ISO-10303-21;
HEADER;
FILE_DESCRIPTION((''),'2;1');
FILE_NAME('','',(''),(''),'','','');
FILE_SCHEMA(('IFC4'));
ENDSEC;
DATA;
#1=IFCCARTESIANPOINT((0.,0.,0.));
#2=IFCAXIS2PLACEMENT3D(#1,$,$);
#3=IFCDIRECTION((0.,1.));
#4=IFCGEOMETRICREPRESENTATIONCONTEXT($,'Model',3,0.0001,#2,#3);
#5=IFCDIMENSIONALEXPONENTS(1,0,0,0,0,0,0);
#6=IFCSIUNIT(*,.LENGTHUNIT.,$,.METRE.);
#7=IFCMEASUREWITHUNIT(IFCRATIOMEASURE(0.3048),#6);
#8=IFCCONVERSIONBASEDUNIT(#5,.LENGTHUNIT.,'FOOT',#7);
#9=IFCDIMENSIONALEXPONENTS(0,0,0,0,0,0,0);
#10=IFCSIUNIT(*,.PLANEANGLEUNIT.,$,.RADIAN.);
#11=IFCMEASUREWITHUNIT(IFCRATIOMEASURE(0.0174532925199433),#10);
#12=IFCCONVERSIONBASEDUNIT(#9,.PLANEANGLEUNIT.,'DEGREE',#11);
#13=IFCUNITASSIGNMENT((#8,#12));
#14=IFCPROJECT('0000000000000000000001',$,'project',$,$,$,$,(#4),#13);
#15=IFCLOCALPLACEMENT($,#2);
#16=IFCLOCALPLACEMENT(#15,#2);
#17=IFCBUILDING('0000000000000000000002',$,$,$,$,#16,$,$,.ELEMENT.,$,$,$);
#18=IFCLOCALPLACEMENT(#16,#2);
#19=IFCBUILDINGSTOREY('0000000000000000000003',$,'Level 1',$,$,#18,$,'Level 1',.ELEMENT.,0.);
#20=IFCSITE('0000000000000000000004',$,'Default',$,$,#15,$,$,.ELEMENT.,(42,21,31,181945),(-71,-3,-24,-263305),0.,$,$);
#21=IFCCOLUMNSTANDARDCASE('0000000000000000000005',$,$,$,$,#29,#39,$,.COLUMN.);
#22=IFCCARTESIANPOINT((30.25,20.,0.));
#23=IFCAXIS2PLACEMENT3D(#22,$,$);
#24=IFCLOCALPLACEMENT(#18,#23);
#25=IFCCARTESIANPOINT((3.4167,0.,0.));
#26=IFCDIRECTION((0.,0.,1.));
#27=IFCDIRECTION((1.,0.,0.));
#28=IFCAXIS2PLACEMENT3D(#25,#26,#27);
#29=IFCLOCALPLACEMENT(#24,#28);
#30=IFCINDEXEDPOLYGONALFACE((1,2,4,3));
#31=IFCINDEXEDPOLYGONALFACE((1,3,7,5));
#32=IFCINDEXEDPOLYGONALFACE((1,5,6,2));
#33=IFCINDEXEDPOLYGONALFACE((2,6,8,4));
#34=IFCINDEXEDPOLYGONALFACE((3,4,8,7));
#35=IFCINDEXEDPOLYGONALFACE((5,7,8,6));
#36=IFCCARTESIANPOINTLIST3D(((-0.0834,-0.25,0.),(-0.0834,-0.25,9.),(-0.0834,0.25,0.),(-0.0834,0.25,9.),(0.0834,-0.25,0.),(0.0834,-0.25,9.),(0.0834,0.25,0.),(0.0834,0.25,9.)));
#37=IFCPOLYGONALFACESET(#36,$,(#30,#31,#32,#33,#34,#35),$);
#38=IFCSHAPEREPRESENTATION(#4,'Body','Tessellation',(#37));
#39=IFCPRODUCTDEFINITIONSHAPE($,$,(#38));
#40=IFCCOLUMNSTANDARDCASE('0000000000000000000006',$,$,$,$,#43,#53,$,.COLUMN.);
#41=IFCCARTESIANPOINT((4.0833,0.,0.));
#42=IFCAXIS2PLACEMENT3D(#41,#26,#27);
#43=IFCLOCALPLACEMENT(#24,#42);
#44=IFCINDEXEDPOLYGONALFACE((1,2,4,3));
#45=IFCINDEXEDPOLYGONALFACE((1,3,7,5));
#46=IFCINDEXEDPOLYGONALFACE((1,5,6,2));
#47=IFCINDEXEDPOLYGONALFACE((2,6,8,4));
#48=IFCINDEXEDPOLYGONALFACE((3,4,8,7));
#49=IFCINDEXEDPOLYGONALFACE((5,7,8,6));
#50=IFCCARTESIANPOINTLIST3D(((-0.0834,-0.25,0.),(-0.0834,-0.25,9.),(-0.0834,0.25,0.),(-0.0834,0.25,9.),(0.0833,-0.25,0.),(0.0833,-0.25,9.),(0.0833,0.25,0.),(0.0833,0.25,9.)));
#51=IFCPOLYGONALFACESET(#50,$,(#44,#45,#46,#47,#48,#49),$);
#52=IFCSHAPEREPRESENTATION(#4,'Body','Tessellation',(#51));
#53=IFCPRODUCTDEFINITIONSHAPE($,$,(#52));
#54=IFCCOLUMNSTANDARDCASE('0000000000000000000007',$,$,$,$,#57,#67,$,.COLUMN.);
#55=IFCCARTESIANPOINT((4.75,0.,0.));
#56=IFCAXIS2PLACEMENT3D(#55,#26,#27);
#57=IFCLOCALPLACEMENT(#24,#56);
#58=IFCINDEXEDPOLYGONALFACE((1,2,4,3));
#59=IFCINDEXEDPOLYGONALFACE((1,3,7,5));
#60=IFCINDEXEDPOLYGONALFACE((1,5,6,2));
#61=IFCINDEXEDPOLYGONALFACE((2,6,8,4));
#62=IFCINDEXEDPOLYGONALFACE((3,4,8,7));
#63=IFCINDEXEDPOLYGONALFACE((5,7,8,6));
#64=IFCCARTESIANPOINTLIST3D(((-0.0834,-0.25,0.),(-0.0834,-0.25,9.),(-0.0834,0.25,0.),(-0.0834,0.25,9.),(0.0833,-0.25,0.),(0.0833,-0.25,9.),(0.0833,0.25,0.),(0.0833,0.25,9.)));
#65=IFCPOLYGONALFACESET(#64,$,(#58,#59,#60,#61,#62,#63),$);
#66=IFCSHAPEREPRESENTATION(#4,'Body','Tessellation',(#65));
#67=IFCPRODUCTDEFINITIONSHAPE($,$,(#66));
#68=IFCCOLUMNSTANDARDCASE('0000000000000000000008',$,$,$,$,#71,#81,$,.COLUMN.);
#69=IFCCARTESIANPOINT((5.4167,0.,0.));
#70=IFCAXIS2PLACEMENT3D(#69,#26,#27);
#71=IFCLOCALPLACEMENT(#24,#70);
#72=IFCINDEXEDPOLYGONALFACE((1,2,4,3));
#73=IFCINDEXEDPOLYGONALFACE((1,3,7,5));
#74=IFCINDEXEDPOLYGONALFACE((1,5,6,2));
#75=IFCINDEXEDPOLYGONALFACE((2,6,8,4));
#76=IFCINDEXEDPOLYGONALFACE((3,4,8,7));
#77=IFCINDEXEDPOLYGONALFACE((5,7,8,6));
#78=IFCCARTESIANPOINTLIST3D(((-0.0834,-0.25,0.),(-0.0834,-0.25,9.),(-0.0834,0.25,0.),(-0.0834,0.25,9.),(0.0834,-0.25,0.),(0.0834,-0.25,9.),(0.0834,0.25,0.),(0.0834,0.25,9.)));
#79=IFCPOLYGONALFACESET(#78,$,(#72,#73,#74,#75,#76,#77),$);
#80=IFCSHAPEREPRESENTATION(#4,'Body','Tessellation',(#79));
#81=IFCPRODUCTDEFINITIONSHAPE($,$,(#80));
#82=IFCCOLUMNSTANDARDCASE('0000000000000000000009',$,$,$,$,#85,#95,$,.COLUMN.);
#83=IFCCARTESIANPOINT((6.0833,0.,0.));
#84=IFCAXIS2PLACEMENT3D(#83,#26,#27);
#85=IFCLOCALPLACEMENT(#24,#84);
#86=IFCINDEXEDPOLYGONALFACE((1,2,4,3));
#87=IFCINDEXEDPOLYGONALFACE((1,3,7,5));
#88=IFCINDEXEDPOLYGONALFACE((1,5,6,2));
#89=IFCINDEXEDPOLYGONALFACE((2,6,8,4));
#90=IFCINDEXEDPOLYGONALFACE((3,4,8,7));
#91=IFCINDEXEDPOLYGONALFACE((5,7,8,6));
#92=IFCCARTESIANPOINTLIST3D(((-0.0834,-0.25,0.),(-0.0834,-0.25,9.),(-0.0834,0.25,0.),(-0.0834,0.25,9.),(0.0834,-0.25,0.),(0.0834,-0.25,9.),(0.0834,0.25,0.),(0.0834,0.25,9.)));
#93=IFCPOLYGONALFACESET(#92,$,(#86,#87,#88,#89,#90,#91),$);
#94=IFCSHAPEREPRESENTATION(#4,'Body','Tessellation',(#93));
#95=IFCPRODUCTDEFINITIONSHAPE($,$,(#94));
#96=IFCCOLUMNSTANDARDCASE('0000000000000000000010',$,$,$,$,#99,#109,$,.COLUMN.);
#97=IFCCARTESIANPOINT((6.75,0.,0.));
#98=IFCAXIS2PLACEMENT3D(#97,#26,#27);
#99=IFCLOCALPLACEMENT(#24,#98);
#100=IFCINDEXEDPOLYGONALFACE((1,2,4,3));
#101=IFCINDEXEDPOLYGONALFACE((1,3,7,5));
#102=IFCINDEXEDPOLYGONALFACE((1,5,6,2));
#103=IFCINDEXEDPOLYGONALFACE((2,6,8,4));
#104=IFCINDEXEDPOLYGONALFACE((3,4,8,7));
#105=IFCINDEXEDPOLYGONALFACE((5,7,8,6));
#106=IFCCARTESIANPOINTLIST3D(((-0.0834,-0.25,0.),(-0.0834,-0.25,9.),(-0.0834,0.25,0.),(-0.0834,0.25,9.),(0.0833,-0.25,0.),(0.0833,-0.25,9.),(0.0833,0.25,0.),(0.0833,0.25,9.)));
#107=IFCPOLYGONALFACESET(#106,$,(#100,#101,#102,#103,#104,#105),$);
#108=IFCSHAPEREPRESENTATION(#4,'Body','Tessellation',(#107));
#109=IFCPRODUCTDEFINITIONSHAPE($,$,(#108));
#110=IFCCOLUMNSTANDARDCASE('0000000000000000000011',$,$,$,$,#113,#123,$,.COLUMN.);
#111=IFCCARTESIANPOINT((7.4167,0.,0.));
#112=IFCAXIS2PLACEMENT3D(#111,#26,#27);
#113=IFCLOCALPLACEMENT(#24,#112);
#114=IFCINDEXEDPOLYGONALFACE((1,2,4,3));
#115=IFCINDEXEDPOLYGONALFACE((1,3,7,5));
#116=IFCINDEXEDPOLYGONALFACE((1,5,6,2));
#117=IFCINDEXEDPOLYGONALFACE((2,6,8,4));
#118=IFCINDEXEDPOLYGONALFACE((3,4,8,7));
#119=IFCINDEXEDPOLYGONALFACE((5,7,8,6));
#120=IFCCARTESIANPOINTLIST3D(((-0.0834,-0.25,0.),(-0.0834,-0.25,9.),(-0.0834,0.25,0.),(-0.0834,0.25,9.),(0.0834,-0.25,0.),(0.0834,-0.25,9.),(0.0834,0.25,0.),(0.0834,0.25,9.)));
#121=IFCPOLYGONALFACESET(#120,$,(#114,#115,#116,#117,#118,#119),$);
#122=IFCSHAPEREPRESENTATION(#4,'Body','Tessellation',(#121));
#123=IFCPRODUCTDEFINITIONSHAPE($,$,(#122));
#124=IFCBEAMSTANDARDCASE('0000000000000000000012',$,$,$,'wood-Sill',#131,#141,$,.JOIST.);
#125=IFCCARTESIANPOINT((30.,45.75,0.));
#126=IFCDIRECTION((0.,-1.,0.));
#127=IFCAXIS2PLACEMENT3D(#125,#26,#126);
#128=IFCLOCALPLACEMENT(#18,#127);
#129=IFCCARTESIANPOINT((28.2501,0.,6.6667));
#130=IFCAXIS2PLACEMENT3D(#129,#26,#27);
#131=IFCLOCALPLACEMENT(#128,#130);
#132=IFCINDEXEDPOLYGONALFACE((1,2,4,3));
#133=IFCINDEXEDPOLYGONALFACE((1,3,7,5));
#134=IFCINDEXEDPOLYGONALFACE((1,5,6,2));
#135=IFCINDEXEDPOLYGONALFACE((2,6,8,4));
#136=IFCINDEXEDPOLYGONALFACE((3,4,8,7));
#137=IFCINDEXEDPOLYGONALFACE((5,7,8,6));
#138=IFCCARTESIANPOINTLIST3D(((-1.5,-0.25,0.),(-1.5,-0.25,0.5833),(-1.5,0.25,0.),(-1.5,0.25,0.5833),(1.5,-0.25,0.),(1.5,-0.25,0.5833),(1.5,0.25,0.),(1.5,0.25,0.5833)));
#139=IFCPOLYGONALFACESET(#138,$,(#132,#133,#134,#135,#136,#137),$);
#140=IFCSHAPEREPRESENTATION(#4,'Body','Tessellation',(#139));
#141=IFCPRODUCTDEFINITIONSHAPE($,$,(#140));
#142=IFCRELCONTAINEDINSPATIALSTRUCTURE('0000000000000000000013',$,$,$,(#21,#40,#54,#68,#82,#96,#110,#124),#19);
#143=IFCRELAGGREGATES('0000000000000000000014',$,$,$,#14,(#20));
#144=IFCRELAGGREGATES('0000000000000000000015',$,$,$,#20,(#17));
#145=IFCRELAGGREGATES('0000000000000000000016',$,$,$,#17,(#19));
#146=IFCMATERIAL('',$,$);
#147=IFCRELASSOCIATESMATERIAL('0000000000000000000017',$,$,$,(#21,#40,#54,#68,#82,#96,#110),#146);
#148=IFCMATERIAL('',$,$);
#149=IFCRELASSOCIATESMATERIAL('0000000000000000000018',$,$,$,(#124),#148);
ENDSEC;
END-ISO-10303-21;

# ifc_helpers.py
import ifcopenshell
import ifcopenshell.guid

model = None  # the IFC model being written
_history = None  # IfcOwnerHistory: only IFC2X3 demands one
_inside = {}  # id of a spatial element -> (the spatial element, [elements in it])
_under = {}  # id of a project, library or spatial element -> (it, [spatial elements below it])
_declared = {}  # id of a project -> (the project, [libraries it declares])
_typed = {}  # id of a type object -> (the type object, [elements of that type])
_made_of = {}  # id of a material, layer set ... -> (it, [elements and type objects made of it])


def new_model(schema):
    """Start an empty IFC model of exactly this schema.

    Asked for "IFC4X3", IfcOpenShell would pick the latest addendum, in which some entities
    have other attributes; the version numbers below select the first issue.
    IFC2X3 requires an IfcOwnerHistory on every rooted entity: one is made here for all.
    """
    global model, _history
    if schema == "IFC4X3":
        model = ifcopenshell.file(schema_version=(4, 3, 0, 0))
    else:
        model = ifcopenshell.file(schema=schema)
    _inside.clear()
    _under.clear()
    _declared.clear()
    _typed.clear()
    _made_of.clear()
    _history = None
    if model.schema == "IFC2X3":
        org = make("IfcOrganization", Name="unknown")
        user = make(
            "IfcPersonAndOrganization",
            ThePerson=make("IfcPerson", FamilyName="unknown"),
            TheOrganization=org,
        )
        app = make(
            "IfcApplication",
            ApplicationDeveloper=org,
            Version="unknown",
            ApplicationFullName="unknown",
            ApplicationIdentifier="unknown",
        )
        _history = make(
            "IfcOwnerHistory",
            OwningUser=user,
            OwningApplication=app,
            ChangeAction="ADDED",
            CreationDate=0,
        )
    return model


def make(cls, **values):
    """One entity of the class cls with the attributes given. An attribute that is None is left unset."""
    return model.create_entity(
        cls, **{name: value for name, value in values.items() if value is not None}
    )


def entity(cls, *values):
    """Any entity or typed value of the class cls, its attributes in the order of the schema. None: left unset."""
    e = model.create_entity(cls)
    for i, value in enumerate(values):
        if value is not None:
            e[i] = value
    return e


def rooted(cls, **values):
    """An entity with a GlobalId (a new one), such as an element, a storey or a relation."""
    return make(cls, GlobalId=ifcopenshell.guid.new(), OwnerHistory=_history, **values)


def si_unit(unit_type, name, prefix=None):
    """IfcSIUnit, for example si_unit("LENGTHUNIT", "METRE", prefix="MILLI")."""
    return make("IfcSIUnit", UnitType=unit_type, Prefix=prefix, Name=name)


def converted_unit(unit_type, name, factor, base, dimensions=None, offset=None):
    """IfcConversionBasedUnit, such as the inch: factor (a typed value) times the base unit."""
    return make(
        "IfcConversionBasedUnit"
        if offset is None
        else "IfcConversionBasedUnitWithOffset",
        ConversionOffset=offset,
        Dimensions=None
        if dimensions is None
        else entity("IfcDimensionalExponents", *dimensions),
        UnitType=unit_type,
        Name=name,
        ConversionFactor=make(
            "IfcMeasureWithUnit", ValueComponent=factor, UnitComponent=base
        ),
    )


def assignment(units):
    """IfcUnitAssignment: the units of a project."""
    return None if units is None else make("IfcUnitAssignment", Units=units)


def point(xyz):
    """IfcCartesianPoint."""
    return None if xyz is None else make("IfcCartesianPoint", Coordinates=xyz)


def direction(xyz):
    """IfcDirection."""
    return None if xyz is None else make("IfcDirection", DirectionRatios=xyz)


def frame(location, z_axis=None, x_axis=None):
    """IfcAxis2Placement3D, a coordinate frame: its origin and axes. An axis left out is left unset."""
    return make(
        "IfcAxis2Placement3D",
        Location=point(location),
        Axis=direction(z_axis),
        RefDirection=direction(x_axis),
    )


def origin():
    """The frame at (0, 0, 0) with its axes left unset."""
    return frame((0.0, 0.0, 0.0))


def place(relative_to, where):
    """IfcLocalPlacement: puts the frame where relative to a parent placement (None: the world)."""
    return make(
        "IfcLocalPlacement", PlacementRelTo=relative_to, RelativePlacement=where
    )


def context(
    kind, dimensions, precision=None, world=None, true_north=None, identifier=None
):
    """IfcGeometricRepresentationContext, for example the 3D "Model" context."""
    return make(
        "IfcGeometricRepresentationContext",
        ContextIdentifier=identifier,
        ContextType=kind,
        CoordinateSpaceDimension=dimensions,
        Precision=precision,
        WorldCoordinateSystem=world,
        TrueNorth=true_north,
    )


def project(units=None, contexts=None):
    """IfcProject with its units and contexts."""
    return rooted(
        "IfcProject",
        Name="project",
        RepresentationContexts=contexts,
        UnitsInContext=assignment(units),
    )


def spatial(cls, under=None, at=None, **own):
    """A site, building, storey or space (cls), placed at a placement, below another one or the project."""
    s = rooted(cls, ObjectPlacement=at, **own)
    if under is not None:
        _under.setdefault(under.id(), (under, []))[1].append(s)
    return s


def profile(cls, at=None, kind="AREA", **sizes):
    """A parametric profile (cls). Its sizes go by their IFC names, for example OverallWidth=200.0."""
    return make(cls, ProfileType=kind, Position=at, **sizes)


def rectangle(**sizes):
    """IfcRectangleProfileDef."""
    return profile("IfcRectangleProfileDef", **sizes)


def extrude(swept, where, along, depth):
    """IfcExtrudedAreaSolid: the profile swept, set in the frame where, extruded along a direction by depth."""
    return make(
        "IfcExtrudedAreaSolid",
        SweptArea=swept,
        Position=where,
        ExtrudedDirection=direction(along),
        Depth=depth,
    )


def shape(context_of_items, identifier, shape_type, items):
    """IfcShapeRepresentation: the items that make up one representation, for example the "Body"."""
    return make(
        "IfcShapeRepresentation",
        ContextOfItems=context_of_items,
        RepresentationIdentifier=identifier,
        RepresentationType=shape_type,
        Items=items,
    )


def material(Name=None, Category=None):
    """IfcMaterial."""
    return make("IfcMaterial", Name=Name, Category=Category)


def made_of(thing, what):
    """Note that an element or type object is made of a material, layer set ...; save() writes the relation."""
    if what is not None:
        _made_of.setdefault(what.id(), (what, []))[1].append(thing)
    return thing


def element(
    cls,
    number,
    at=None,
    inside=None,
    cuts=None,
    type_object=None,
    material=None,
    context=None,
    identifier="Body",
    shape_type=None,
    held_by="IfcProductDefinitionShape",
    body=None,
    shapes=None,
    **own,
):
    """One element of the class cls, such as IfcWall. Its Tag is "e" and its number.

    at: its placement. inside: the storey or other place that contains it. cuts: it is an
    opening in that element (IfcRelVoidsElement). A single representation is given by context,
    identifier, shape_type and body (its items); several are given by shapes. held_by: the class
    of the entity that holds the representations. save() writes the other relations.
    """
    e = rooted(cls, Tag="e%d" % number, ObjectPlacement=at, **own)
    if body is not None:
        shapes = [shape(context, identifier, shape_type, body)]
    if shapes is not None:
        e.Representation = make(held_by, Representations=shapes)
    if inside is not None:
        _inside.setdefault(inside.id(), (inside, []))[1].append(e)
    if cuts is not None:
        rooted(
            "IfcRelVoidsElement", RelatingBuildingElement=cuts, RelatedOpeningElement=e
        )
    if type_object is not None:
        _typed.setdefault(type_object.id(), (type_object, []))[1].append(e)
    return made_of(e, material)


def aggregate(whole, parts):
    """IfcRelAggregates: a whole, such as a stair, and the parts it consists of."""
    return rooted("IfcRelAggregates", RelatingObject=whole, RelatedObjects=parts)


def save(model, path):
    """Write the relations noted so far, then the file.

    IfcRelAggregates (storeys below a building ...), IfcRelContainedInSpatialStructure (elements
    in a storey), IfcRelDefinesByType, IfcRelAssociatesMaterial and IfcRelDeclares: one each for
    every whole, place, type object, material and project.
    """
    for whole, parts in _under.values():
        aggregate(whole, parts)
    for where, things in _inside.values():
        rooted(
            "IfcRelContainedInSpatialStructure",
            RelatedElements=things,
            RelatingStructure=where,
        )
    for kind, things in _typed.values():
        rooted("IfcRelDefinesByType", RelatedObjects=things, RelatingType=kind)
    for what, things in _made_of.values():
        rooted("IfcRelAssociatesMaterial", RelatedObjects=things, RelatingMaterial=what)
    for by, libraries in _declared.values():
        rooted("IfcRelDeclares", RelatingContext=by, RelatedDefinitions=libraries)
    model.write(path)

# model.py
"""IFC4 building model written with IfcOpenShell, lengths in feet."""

from ifc_helpers import new_model, entity, si_unit, converted_unit, direction, frame, origin, place, context, project, spatial, rectangle, extrude, material, element, save


model = new_model("IFC4")

# Units and contexts
model_context = context("Model", 3, precision=0.0001, world=origin(), true_north=direction((0.0, 1.0)))
ifc_project = project(units=[converted_unit("LENGTHUNIT", "FOOT", entity("IfcRatioMeasure", 0.3048), si_unit("LENGTHUNIT", "METRE"), dimensions=[1, 0, 0, 0, 0, 0, 0]), converted_unit("PLANEANGLEUNIT", "DEGREE", entity("IfcRatioMeasure", 0.0174532925199433), si_unit("PLANEANGLEUNIT", "RADIAN"), dimensions=[0, 0, 0, 0, 0, 0, 0])], contexts=[model_context])

# Site, building, storey
site_placement = place(None, origin())
site = spatial("IfcSite", under=ifc_project, at=site_placement, Name="Default", CompositionType="ELEMENT", RefLatitude=(42, 21, 31, 181945), RefLongitude=(-71, -3, -24, -263305), RefElevation=0.0)
building_placement = place(site_placement, origin())
building = spatial("IfcBuilding", under=site, at=building_placement, CompositionType="ELEMENT")
storey_placement = place(building_placement, origin())
storey = spatial("IfcBuildingStorey", under=building, at=storey_placement, Name="Level 1", LongName="Level 1", CompositionType="ELEMENT", Elevation=0.0)

# Columns
ifc_material_1 = material(Name="")
placement_1 = place(storey_placement, frame((30.0, 45.75, 0.0), z_axis=(0.0, 0.0, 1.0), x_axis=(0.0, -1.0, 0.0)))
placement_2 = place(storey_placement, frame((30.25, 20.0, 0.0)))
for number, where, z_axis, x_axis in (
    (1, (3.4167, 0.0, 0.0), (0.0, 0.0, 1.0), (1.0, 0.0, 0.0)),
    (2, (4.0833, 0.0, 0.0), (0.0, 0.0, 1.0), (1.0, 0.0, 0.0)),
    (3, (4.75, 0.0, 0.0), (0.0, 0.0, 1.0), (1.0, 0.0, 0.0)),
    (4, (5.4167, 0.0, 0.0), (0.0, 0.0, 1.0), (1.0, 0.0, 0.0)),
    (5, (6.0833, 0.0, 0.0), (0.0, 0.0, 1.0), (1.0, 0.0, 0.0)),
    (6, (6.75, 0.0, 0.0), (0.0, 0.0, 1.0), (1.0, 0.0, 0.0)),
    (7, (7.4167, 0.0, 0.0), (0.0, 0.0, 1.0), (1.0, 0.0, 0.0)),
):
    element("IfcColumnStandardCase", number, at=place(placement_2, frame(where, z_axis=z_axis, x_axis=x_axis)), inside=storey, material=ifc_material_1, PredefinedType="COLUMN", context=model_context, shape_type="SweptSolid", body=[
        extrude(rectangle(XDim=0.1667, YDim=0.5), origin(), (0.0, 0.0, 1.0), 9.0),
    ])

# Beam
ifc_material_2 = material(Name="")
for number, where, z_axis, x_axis in (
    (8, (28.2501, 0.0, 6.6667), (0.0, 0.0, 1.0), (1.0, 0.0, 0.0)),
):
    element("IfcBeamStandardCase", number, at=place(placement_1, frame(where, z_axis=z_axis, x_axis=x_axis)), inside=storey, material=ifc_material_2, ObjectType="wood-Sill", PredefinedType="JOIST", context=model_context, shape_type="SweptSolid", body=[
        extrude(rectangle(XDim=3.0, YDim=0.5), origin(), (0.0, 0.0, 1.0), 0.5833),
    ])

save(model, "model.ifc")
